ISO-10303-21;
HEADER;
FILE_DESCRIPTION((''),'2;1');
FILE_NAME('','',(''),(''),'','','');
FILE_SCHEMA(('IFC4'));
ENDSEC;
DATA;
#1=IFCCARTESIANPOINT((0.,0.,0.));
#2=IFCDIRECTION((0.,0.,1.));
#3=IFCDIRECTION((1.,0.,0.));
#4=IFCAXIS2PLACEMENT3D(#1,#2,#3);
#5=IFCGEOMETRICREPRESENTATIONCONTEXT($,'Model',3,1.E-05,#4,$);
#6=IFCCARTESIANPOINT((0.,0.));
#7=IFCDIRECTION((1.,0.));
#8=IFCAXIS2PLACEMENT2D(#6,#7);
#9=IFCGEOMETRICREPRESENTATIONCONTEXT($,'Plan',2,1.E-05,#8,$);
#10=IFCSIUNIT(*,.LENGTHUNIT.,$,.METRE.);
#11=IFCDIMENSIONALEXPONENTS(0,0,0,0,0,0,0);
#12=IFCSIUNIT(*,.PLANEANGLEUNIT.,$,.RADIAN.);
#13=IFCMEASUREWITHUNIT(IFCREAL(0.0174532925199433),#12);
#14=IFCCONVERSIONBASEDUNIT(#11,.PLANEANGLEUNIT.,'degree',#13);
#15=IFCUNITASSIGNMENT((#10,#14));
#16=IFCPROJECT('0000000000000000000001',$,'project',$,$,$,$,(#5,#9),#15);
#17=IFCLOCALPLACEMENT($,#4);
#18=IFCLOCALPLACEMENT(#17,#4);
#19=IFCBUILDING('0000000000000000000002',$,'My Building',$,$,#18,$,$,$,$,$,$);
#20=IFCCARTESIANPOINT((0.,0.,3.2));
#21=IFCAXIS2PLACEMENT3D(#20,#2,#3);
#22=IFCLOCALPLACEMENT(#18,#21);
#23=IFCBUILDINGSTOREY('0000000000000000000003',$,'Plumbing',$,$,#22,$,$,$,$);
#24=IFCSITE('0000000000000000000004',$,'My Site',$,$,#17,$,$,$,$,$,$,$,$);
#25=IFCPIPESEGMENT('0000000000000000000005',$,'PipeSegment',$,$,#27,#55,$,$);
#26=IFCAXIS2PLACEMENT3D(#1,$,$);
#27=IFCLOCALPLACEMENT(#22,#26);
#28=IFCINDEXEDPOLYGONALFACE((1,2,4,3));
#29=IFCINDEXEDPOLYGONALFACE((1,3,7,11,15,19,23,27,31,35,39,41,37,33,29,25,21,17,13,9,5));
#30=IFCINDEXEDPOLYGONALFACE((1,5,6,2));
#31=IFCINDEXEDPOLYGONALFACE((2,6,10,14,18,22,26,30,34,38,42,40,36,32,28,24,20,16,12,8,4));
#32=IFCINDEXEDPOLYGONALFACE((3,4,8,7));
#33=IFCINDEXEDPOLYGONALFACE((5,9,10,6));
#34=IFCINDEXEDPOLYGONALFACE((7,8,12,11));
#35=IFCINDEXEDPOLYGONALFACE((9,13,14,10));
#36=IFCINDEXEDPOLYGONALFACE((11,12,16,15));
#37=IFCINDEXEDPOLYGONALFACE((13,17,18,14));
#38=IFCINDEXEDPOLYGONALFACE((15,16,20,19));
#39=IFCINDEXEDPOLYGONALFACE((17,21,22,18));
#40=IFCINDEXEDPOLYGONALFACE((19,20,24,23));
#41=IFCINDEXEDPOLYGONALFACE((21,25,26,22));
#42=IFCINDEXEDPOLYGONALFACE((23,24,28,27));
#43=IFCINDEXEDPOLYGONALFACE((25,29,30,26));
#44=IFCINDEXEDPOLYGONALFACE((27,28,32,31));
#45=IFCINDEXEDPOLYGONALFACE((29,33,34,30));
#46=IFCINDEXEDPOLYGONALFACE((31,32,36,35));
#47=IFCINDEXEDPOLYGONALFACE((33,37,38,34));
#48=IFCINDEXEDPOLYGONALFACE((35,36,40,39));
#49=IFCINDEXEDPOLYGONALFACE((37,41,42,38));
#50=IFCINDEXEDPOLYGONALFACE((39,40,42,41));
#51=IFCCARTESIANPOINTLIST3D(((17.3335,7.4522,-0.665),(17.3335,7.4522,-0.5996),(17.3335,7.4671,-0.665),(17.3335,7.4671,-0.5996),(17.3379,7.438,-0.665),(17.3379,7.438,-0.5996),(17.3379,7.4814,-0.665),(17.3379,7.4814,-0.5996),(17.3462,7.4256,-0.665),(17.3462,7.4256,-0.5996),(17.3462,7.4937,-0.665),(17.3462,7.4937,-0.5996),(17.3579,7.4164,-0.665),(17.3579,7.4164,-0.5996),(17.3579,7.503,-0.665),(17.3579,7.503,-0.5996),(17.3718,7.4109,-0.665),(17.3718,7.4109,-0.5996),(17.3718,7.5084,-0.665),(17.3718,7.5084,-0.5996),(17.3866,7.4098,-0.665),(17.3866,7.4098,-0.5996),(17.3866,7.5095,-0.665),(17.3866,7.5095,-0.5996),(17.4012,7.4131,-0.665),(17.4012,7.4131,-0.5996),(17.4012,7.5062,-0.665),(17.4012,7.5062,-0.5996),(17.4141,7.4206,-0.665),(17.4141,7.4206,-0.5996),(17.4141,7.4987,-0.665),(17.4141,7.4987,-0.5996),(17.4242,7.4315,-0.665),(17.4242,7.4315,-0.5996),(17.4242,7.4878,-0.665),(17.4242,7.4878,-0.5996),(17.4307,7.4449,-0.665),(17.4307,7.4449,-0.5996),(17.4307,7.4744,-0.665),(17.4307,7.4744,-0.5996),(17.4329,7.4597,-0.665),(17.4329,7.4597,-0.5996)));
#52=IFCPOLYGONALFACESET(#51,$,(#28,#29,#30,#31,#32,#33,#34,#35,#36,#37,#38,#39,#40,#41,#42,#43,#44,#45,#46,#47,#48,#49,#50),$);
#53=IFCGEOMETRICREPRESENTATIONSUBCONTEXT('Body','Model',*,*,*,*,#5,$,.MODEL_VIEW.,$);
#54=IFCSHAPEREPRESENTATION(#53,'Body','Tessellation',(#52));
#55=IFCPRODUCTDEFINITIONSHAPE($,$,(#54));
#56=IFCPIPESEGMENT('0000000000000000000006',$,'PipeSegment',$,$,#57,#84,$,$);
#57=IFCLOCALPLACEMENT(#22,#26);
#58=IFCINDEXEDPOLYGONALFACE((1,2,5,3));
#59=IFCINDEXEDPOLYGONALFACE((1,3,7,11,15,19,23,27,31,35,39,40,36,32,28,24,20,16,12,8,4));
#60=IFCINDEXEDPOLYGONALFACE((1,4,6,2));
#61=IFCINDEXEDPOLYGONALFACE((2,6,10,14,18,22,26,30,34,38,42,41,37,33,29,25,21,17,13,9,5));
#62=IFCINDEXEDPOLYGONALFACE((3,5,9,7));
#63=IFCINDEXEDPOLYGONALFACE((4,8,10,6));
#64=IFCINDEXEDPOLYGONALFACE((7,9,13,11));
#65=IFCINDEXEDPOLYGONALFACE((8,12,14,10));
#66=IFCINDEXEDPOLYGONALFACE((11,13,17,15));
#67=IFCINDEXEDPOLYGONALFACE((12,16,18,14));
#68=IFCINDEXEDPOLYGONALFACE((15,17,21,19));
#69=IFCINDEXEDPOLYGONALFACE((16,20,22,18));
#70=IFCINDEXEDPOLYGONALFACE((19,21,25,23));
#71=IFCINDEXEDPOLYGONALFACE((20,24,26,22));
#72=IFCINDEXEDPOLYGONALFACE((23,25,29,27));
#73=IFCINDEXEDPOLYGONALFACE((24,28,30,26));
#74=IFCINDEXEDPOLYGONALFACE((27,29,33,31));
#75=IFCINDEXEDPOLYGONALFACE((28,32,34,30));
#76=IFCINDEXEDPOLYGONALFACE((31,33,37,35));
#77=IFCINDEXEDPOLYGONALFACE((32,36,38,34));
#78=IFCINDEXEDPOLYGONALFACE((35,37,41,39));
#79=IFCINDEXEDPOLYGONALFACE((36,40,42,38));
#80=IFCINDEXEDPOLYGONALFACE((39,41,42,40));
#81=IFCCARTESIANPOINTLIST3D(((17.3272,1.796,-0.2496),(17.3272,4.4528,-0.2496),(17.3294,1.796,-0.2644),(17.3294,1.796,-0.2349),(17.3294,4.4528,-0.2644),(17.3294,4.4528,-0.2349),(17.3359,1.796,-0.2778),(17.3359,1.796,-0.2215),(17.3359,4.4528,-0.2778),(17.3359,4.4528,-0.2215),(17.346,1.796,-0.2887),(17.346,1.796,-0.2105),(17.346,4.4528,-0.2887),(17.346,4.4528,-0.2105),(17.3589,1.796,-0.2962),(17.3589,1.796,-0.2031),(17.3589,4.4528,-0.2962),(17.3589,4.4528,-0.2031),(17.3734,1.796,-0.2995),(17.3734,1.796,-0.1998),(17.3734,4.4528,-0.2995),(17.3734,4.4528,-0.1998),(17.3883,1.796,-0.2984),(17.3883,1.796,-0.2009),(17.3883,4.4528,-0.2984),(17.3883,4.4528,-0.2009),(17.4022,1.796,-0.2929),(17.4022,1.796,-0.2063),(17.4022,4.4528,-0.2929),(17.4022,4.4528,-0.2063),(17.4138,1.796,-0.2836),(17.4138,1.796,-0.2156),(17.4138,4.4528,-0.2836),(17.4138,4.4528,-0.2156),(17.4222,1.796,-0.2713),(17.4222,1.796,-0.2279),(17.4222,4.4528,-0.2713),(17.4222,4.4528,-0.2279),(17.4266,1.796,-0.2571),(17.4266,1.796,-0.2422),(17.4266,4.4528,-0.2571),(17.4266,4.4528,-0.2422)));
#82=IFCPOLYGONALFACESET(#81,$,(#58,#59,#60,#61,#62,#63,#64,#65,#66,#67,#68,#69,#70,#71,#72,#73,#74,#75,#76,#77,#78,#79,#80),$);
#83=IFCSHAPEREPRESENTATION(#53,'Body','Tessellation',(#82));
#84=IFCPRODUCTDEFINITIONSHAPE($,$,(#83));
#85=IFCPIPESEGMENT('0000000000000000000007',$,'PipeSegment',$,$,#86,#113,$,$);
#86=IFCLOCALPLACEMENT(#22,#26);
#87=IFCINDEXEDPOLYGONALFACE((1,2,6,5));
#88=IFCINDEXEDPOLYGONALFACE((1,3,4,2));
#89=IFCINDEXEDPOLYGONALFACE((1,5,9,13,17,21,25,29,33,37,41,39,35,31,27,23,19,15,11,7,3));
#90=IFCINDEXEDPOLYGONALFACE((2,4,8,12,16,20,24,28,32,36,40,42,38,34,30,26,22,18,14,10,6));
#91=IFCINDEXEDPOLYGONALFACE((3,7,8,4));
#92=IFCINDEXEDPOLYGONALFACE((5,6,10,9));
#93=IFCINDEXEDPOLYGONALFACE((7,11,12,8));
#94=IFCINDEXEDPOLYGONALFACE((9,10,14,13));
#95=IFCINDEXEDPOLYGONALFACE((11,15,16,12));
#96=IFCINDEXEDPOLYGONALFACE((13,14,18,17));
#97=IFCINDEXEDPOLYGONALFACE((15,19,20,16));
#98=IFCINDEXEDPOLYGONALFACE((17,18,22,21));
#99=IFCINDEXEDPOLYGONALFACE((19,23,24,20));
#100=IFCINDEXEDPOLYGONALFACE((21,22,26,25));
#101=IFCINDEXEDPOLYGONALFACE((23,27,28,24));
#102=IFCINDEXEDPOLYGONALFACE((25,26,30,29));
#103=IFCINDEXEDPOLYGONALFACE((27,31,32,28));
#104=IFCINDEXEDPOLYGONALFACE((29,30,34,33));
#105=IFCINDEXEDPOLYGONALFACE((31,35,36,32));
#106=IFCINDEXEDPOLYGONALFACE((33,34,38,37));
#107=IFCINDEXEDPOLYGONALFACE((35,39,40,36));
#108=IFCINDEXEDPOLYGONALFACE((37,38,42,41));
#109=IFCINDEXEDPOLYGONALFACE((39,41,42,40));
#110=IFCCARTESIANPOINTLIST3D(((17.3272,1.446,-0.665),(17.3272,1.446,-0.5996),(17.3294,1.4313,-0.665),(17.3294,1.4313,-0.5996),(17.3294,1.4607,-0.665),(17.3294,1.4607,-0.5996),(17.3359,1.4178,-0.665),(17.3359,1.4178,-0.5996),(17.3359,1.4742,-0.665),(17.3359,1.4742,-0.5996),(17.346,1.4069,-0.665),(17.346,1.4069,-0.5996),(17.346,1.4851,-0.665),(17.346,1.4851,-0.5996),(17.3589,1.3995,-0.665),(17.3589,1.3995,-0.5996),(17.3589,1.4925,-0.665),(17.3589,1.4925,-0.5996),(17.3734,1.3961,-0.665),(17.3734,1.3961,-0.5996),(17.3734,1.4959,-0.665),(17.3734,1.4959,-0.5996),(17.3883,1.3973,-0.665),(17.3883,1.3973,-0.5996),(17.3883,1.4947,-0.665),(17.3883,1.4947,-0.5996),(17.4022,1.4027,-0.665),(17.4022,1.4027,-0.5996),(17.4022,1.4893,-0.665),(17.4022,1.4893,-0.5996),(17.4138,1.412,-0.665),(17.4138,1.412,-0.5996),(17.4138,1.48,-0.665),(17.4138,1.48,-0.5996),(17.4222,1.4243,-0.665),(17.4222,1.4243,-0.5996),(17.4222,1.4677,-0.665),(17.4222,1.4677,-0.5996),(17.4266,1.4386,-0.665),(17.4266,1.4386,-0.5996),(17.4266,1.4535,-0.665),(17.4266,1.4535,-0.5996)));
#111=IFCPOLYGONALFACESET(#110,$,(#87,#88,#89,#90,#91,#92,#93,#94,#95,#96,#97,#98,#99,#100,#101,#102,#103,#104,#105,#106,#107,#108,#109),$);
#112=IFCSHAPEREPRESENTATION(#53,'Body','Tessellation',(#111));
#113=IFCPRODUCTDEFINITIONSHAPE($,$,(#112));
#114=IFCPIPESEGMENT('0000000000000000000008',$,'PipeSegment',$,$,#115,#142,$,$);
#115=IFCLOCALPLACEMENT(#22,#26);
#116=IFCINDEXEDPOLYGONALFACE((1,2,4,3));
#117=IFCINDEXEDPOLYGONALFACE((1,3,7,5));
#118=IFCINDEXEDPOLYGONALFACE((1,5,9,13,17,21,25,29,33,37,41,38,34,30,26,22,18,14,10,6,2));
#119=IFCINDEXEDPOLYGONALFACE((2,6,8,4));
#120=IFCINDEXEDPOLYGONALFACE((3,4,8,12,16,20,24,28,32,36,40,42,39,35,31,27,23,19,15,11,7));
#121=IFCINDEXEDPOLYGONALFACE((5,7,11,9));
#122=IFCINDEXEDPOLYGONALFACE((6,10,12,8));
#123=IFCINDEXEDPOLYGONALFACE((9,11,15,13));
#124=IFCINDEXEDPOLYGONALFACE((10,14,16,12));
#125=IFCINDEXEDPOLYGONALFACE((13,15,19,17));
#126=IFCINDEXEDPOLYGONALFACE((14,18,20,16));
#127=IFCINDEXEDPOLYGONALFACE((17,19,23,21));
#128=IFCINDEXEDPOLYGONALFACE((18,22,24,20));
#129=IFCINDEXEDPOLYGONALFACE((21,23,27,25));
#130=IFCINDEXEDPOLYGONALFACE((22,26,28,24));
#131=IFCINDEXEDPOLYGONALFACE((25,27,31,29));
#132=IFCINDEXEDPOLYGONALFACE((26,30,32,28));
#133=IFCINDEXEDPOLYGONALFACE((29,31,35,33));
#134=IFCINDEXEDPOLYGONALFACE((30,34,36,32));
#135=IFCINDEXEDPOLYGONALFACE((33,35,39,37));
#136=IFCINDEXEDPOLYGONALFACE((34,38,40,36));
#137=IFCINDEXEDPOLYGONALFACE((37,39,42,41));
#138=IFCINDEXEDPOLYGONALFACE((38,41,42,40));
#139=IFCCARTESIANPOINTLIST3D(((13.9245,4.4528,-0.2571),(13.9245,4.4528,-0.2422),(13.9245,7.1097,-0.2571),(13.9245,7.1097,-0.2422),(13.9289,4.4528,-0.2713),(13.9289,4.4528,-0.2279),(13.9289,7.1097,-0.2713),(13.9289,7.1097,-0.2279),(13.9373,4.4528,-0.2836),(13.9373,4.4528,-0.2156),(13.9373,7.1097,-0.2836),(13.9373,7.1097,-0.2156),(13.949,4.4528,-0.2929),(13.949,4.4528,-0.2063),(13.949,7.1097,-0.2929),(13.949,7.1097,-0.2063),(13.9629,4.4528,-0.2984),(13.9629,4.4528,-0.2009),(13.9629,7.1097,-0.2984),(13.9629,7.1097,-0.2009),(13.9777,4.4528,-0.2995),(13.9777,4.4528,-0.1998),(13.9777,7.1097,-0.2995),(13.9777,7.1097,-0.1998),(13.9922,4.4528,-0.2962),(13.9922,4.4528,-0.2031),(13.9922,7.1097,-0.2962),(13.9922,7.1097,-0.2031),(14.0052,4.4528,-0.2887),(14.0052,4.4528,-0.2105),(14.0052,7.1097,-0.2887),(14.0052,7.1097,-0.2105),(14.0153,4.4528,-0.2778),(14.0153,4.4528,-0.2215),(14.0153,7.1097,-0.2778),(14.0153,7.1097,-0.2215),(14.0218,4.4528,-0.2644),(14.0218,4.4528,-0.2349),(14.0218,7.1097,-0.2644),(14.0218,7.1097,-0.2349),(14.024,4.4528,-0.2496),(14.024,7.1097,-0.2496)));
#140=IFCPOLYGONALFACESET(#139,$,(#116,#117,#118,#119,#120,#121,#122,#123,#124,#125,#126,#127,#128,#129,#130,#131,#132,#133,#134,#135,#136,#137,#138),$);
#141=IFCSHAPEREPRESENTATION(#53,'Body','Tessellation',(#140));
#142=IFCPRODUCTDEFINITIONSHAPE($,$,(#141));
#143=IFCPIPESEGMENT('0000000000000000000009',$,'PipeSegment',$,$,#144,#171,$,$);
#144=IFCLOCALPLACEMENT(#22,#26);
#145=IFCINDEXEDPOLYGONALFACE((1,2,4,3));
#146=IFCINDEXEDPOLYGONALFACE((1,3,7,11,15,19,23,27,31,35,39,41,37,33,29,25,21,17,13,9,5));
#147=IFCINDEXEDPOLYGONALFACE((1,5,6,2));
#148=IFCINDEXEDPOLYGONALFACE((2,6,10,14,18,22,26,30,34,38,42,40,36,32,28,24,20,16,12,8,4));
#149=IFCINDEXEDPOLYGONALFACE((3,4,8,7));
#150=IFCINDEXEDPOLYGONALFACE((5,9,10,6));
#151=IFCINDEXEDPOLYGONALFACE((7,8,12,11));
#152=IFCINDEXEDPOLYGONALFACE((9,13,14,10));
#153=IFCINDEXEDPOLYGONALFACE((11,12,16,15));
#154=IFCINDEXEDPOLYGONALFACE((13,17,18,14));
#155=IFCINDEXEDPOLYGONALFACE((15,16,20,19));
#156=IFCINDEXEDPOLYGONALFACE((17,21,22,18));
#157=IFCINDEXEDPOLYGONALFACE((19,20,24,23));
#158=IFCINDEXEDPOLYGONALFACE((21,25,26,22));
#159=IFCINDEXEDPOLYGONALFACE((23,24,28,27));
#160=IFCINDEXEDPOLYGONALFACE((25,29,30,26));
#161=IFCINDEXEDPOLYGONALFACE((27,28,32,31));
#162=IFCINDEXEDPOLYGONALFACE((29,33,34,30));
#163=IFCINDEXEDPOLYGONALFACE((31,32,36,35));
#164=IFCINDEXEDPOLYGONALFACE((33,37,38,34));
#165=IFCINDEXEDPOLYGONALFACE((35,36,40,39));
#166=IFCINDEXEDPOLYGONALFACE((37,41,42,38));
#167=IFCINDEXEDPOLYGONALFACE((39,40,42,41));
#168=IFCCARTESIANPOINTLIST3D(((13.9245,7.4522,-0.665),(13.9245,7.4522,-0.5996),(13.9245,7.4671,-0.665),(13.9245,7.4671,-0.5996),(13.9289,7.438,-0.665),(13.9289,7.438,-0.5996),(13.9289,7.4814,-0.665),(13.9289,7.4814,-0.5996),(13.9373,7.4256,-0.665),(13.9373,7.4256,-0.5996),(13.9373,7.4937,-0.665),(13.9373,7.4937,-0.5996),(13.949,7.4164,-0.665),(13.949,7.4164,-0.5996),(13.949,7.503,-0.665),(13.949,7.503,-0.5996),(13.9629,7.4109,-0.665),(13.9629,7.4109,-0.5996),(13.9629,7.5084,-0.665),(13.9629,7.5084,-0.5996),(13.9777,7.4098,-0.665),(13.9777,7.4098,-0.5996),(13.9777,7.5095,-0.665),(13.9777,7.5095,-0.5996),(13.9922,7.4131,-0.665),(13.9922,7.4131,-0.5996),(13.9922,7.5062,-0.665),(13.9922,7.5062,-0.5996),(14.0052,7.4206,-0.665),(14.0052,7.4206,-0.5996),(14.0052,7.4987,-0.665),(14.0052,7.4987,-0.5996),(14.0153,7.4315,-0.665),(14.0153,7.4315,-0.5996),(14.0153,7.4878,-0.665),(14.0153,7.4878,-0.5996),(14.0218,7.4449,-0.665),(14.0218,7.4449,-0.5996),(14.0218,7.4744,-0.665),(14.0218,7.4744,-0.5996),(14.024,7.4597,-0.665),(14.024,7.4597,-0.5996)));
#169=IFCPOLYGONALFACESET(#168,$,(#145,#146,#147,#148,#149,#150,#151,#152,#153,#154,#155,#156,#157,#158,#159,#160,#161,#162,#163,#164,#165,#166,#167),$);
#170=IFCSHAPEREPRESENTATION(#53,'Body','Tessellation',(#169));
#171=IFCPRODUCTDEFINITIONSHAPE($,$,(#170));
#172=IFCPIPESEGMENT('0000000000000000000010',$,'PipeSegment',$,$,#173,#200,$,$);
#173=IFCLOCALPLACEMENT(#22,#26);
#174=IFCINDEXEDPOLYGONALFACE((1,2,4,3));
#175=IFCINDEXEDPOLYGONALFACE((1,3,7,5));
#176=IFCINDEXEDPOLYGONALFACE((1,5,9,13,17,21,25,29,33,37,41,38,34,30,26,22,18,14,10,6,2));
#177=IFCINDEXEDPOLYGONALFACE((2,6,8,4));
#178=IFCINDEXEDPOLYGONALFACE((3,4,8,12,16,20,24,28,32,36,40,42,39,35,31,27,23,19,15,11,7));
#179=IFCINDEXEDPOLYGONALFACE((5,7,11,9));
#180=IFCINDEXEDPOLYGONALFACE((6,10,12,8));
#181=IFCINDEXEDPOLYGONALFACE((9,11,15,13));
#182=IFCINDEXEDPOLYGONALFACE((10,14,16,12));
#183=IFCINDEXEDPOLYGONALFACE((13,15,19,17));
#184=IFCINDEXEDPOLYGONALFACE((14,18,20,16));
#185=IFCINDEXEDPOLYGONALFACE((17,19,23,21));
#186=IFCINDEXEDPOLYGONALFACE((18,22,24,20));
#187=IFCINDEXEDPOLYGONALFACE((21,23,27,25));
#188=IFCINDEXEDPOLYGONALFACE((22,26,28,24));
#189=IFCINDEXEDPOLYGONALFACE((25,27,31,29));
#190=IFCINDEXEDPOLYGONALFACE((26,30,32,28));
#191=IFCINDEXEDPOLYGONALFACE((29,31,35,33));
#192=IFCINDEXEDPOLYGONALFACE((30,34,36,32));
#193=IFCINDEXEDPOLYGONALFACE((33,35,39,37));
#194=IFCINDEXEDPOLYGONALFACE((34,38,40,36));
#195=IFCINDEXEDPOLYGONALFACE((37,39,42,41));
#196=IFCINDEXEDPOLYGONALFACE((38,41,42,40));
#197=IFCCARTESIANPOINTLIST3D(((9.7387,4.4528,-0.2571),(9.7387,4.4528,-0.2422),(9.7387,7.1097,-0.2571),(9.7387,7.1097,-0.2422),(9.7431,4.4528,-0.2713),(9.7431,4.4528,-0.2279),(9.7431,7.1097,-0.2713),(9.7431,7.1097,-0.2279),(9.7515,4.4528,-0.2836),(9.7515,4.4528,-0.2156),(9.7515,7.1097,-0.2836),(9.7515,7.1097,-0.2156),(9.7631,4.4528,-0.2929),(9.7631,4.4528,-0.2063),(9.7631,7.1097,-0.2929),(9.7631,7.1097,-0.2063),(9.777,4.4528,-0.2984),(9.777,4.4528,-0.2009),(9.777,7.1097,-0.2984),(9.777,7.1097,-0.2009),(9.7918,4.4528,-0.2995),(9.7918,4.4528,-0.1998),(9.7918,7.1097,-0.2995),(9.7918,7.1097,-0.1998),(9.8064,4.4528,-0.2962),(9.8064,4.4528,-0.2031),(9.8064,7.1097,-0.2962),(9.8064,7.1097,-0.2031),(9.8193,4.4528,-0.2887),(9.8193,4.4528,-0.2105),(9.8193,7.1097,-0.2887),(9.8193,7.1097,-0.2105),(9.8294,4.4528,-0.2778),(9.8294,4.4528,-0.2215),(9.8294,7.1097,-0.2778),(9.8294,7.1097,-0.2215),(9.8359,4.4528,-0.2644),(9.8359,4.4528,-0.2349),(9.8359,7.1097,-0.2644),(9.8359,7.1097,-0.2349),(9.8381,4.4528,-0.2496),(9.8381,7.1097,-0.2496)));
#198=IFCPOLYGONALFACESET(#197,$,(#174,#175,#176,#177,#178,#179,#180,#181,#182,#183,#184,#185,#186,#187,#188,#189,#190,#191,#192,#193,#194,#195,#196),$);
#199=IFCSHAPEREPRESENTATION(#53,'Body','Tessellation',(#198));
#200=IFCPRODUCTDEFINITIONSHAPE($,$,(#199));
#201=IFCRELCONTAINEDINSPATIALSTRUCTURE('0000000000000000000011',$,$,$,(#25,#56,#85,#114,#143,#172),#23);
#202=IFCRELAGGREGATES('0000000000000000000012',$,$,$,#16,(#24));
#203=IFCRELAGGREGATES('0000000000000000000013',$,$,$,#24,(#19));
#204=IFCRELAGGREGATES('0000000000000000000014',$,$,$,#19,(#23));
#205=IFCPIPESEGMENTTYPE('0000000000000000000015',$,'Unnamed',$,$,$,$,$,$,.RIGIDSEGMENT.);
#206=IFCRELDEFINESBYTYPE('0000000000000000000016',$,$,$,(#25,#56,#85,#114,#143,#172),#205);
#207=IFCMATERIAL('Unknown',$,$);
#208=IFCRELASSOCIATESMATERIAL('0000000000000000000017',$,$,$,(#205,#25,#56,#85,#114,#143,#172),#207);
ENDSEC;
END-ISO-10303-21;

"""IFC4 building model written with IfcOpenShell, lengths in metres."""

from ifc_helpers import new_model, entity, si_unit, converted_unit, frame, origin_with_axes, origin_2d_with_axis, place, context, subcontext, project, spatial, circle, extrude, material, material_profile, profile_set, profile_usage, type_object, element, save


model = new_model("IFC4")

# Units and contexts
model_context = context("Model", 3, precision=1e-05, world=origin_with_axes())
plan_context = context("Plan", 2, precision=1e-05, world=origin_2d_with_axis())
body_context = subcontext(model_context, "Body", "Model", "MODEL_VIEW")
ifc_project = project(units=[si_unit("LENGTHUNIT", "METRE"), converted_unit("PLANEANGLEUNIT", "degree", entity("IfcReal", 0.0174532925199433), si_unit("PLANEANGLEUNIT", "RADIAN"), dimensions=[0, 0, 0, 0, 0, 0, 0])], contexts=[model_context, plan_context])

# Site, building, storey
site_placement = place(None, origin_with_axes())
site = spatial("IfcSite", under=ifc_project, at=site_placement, Name="My Site")
building_placement = place(site_placement, origin_with_axes())
building = spatial("IfcBuilding", under=site, at=building_placement, Name="My Building")
storey_placement = place(building_placement, frame((0.0, 0.0, 3.2), z_axis=(0.0, 0.0, 1.0), x_axis=(1.0, 0.0, 0.0)))
storey = spatial("IfcBuildingStorey", under=building, at=storey_placement, Name="Plumbing")

# Pipe segments
ifc_material = material(Name="Unknown")
ifc_material_profile = material_profile(ifc_material, circle(Radius=0.05))
ifc_profile_set = profile_set([ifc_material_profile])
pipe_segment_type = type_object("IfcPipeSegmentType", Name="Unnamed", PredefinedType="RIGIDSEGMENT", material=ifc_profile_set)
ifc_profile_usage_1 = profile_usage(ifc_profile_set, cardinal=5)
pipe_segment_1_placement = place(storey_placement, frame((17.3829, 7.4597, -0.5996), z_axis=(0.0, 0.0, -1.0), x_axis=(1.0, 0.0, 0.0)))
element("IfcPipeSegment", 1, at=pipe_segment_1_placement, inside=storey, type_object=pipe_segment_type, material=ifc_profile_usage_1, Name="PipeSegment", context=body_context, shape_type="SweptSolid", body=[
    extrude(circle(Radius=0.05), origin_with_axes(), (0.0, 0.0, 1.0), 0.0654),
])
ifc_profile_usage_2 = profile_usage(ifc_profile_set, cardinal=5)
pipe_segment_2_placement = place(storey_placement, frame((17.3772, 1.796, -0.2496), z_axis=(0.0, 1.0, 0.0), x_axis=(-1.0, 0.0, 0.0)))
element("IfcPipeSegment", 2, at=pipe_segment_2_placement, inside=storey, type_object=pipe_segment_type, material=ifc_profile_usage_2, Name="PipeSegment", context=body_context, shape_type="SweptSolid", body=[
    extrude(circle(Radius=0.05), origin_with_axes(), (0.0, 0.0, 1.0), 2.6568),
])
ifc_profile_usage_3 = profile_usage(ifc_profile_set, cardinal=5)
pipe_segment_3_placement = place(storey_placement, frame((17.3772, 1.446, -0.5996), z_axis=(0.0, 0.0, -1.0), x_axis=(-1.0, 0.0, 0.0)))
element("IfcPipeSegment", 3, at=pipe_segment_3_placement, inside=storey, type_object=pipe_segment_type, material=ifc_profile_usage_3, Name="PipeSegment", context=body_context, shape_type="SweptSolid", body=[
    extrude(circle(Radius=0.05), origin_with_axes(), (0.0, 0.0, 1.0), 0.0654),
])
ifc_profile_usage_4 = profile_usage(ifc_profile_set, cardinal=5)
pipe_segment_4_placement = place(storey_placement, frame((13.974, 7.1097, -0.2496), z_axis=(0.0, -1.0, 0.0), x_axis=(1.0, 0.0, 0.0)))
element("IfcPipeSegment", 4, at=pipe_segment_4_placement, inside=storey, type_object=pipe_segment_type, material=ifc_profile_usage_4, Name="PipeSegment", context=body_context, shape_type="SweptSolid", body=[
    extrude(circle(Radius=0.05), origin_with_axes(), (0.0, 0.0, 1.0), 2.6568),
])
ifc_profile_usage_5 = profile_usage(ifc_profile_set, cardinal=5)
pipe_segment_5_placement = place(storey_placement, frame((13.974, 7.4597, -0.5996), z_axis=(0.0, 0.0, -1.0), x_axis=(1.0, 0.0, 0.0)))
element("IfcPipeSegment", 5, at=pipe_segment_5_placement, inside=storey, type_object=pipe_segment_type, material=ifc_profile_usage_5, Name="PipeSegment", context=body_context, shape_type="SweptSolid", body=[
    extrude(circle(Radius=0.05), origin_with_axes(), (0.0, 0.0, 1.0), 0.0654),
])
ifc_profile_usage_6 = profile_usage(ifc_profile_set, cardinal=5)
pipe_segment_6_placement = place(storey_placement, frame((9.7881, 7.1097, -0.2496), z_axis=(0.0, -1.0, 0.0), x_axis=(1.0, 0.0, 0.0)))
element("IfcPipeSegment", 6, at=pipe_segment_6_placement, inside=storey, type_object=pipe_segment_type, material=ifc_profile_usage_6, Name="PipeSegment", context=body_context, shape_type="SweptSolid", body=[
    extrude(circle(Radius=0.05), origin_with_axes(), (0.0, 0.0, 1.0), 2.6568),
])

save(model, "model.ifc")
